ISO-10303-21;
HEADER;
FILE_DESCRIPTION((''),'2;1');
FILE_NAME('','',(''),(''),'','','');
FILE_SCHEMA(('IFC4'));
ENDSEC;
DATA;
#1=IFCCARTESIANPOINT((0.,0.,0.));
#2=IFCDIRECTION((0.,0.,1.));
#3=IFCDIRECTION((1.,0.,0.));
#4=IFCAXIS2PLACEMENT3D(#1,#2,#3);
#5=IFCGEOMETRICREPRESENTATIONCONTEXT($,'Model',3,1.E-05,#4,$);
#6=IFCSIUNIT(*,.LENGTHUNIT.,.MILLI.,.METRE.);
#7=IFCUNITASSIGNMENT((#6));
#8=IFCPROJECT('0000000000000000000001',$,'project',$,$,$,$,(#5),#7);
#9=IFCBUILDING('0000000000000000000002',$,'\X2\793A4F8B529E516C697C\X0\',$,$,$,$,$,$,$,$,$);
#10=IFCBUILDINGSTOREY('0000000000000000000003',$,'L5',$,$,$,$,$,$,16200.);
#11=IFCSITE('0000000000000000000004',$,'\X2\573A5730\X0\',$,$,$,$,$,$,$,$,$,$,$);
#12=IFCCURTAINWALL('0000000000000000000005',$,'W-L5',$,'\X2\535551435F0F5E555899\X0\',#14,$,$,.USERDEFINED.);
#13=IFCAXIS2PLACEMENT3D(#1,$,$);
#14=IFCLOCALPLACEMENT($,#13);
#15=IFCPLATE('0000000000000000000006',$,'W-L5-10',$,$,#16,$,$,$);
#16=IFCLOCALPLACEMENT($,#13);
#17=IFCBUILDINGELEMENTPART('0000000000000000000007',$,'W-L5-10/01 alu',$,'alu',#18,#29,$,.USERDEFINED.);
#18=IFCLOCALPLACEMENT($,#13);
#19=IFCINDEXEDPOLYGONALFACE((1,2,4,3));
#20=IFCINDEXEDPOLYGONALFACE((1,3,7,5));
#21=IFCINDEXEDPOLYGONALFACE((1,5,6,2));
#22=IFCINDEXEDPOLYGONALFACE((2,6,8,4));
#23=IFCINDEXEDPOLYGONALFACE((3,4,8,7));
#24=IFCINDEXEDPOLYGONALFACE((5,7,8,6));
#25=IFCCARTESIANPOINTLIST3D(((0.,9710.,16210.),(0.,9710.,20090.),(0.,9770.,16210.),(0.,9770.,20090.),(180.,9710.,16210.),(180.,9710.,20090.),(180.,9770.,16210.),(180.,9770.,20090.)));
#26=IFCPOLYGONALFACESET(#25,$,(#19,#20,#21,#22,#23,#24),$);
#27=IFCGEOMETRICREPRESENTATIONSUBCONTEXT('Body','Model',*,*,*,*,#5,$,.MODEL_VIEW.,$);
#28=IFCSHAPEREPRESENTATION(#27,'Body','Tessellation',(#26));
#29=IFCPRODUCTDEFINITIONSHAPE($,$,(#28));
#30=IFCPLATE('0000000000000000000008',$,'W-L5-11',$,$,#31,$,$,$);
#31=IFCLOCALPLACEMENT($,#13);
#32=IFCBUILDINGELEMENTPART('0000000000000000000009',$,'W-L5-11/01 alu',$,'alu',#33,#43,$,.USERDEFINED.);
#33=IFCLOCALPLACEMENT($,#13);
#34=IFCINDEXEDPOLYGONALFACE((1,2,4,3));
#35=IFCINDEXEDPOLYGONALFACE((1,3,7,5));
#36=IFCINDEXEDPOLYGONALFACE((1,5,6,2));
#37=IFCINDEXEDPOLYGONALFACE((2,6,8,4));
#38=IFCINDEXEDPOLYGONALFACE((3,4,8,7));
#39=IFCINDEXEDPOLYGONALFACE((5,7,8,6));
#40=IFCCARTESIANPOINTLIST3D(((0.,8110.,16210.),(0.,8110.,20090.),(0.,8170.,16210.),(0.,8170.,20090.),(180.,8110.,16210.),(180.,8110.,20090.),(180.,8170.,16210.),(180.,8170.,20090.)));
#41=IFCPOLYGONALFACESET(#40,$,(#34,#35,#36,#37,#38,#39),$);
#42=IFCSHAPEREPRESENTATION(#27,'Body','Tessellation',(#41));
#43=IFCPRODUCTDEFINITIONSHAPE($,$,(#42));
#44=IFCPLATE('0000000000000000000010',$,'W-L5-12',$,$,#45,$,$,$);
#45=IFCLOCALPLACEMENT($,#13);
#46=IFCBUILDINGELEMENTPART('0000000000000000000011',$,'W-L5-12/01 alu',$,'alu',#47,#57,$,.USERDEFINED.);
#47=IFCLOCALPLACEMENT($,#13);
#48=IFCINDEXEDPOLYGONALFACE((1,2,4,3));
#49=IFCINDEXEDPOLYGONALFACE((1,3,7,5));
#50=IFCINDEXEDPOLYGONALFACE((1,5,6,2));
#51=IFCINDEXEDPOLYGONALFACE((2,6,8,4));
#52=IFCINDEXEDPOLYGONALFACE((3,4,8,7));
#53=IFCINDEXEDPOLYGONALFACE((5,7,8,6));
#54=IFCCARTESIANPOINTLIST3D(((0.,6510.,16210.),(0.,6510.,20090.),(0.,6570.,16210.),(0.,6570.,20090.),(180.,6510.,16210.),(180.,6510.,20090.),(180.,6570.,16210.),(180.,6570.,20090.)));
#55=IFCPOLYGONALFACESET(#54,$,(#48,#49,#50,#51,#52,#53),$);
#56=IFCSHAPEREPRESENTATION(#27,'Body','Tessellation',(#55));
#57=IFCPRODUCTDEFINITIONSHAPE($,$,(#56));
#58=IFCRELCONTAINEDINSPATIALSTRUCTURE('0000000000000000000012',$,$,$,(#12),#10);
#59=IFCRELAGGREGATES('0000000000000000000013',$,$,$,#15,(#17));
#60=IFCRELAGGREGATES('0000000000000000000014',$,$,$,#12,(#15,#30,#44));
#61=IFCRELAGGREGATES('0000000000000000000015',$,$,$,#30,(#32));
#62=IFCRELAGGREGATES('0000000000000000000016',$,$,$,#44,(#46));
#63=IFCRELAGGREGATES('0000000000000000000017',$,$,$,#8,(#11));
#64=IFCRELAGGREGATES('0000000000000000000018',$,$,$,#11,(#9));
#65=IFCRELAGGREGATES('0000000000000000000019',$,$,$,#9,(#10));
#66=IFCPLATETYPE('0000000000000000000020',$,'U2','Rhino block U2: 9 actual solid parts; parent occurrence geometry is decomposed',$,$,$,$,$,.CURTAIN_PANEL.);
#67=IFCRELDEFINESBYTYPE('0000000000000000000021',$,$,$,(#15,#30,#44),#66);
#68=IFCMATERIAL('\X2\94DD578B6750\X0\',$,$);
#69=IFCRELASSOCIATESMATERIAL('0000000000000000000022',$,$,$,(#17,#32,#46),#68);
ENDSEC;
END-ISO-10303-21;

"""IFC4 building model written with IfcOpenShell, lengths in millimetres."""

from ifc_helpers import new_model, si_unit, frame, frame_2d, origin, origin_with_axes, place, context, subcontext, project, spatial, rectangle, extrude, source, transform, mapped, material, type_object, element, aggregate, save


model = new_model("IFC4")

# Units and contexts
model_context = context("Model", 3, precision=1e-05, world=origin_with_axes())
body_context = subcontext(model_context, "Body", "Model", "MODEL_VIEW")
ifc_project = project(units=[si_unit("LENGTHUNIT", "METRE", prefix="MILLI")], contexts=[model_context])

# Site, building, storey
site = spatial("IfcSite", under=ifc_project, Name="场地")
building = spatial("IfcBuilding", under=site, Name="示例办公楼")
storey = spatial("IfcBuildingStorey", under=building, Name="L5", Elevation=16200.0)

# Curtain wall, plates, building element parts
curtain_wall = element("IfcCurtainWall", 1, inside=storey, Name="W-L5", ObjectType="单元式幕墙", PredefinedType="USERDEFINED")
plate_type = type_object("IfcPlateType", Name="U2", Description="Rhino block U2: 9 actual solid parts; parent occurrence geometry is decomposed", PredefinedType="CURTAIN_PANEL")
plate_1_placement = place(None, frame((0.0, 9770.0, 16210.0), z_axis=(0.0, 0.0, 1.0), x_axis=(0.0, -1.0, 0.0)))
plate_1 = element("IfcPlate", 2, at=plate_1_placement, type_object=plate_type, Name="W-L5-10")
ifc_material_1 = material(Name="铝型材")
shared_shape_1 = source(origin(), body_context, "Body", "SweptSolid", [
    extrude(rectangle(XDim=60.0, YDim=180.0, at=frame_2d((30.0, 90.0))), origin(), (0.0, 0.0, 1.0), 3880.0),
])
building_element_part_1_placement = place(plate_1_placement, origin())
building_element_part_1 = element("IfcBuildingElementPart", 3, at=building_element_part_1_placement, material=ifc_material_1, Name="W-L5-10/01 alu", ObjectType="alu", PredefinedType="USERDEFINED", context=body_context, shape_type="MappedRepresentation", body=[
    mapped(shared_shape_1, transform((0.0, 0.0, 0.0))),
])
plate_2_placement = place(None, frame((0.0, 8170.0, 16210.0), z_axis=(0.0, 0.0, 1.0), x_axis=(0.0, -1.0, 0.0)))
plate_2 = element("IfcPlate", 4, at=plate_2_placement, type_object=plate_type, Name="W-L5-11")
building_element_part_2_placement = place(plate_2_placement, origin())
building_element_part_2 = element("IfcBuildingElementPart", 5, at=building_element_part_2_placement, material=ifc_material_1, Name="W-L5-11/01 alu", ObjectType="alu", PredefinedType="USERDEFINED", context=body_context, shape_type="MappedRepresentation", body=[
    mapped(shared_shape_1, transform((0.0, 0.0, 0.0))),
])
plate_3_placement = place(None, frame((0.0, 6570.0, 16210.0), z_axis=(0.0, 0.0, 1.0), x_axis=(0.0, -1.0, 0.0)))
plate_3 = element("IfcPlate", 6, at=plate_3_placement, type_object=plate_type, Name="W-L5-12")
building_element_part_3_placement = place(plate_3_placement, origin())
building_element_part_3 = element("IfcBuildingElementPart", 7, at=building_element_part_3_placement, material=ifc_material_1, Name="W-L5-12/01 alu", ObjectType="alu", PredefinedType="USERDEFINED", context=body_context, shape_type="MappedRepresentation", body=[
    mapped(shared_shape_1, transform((0.0, 0.0, 0.0))),
])
aggregate(plate_1, [building_element_part_1])
aggregate(curtain_wall, [plate_1, plate_2, plate_3])
aggregate(plate_2, [building_element_part_2])
aggregate(plate_3, [building_element_part_3])

save(model, "model.ifc")
